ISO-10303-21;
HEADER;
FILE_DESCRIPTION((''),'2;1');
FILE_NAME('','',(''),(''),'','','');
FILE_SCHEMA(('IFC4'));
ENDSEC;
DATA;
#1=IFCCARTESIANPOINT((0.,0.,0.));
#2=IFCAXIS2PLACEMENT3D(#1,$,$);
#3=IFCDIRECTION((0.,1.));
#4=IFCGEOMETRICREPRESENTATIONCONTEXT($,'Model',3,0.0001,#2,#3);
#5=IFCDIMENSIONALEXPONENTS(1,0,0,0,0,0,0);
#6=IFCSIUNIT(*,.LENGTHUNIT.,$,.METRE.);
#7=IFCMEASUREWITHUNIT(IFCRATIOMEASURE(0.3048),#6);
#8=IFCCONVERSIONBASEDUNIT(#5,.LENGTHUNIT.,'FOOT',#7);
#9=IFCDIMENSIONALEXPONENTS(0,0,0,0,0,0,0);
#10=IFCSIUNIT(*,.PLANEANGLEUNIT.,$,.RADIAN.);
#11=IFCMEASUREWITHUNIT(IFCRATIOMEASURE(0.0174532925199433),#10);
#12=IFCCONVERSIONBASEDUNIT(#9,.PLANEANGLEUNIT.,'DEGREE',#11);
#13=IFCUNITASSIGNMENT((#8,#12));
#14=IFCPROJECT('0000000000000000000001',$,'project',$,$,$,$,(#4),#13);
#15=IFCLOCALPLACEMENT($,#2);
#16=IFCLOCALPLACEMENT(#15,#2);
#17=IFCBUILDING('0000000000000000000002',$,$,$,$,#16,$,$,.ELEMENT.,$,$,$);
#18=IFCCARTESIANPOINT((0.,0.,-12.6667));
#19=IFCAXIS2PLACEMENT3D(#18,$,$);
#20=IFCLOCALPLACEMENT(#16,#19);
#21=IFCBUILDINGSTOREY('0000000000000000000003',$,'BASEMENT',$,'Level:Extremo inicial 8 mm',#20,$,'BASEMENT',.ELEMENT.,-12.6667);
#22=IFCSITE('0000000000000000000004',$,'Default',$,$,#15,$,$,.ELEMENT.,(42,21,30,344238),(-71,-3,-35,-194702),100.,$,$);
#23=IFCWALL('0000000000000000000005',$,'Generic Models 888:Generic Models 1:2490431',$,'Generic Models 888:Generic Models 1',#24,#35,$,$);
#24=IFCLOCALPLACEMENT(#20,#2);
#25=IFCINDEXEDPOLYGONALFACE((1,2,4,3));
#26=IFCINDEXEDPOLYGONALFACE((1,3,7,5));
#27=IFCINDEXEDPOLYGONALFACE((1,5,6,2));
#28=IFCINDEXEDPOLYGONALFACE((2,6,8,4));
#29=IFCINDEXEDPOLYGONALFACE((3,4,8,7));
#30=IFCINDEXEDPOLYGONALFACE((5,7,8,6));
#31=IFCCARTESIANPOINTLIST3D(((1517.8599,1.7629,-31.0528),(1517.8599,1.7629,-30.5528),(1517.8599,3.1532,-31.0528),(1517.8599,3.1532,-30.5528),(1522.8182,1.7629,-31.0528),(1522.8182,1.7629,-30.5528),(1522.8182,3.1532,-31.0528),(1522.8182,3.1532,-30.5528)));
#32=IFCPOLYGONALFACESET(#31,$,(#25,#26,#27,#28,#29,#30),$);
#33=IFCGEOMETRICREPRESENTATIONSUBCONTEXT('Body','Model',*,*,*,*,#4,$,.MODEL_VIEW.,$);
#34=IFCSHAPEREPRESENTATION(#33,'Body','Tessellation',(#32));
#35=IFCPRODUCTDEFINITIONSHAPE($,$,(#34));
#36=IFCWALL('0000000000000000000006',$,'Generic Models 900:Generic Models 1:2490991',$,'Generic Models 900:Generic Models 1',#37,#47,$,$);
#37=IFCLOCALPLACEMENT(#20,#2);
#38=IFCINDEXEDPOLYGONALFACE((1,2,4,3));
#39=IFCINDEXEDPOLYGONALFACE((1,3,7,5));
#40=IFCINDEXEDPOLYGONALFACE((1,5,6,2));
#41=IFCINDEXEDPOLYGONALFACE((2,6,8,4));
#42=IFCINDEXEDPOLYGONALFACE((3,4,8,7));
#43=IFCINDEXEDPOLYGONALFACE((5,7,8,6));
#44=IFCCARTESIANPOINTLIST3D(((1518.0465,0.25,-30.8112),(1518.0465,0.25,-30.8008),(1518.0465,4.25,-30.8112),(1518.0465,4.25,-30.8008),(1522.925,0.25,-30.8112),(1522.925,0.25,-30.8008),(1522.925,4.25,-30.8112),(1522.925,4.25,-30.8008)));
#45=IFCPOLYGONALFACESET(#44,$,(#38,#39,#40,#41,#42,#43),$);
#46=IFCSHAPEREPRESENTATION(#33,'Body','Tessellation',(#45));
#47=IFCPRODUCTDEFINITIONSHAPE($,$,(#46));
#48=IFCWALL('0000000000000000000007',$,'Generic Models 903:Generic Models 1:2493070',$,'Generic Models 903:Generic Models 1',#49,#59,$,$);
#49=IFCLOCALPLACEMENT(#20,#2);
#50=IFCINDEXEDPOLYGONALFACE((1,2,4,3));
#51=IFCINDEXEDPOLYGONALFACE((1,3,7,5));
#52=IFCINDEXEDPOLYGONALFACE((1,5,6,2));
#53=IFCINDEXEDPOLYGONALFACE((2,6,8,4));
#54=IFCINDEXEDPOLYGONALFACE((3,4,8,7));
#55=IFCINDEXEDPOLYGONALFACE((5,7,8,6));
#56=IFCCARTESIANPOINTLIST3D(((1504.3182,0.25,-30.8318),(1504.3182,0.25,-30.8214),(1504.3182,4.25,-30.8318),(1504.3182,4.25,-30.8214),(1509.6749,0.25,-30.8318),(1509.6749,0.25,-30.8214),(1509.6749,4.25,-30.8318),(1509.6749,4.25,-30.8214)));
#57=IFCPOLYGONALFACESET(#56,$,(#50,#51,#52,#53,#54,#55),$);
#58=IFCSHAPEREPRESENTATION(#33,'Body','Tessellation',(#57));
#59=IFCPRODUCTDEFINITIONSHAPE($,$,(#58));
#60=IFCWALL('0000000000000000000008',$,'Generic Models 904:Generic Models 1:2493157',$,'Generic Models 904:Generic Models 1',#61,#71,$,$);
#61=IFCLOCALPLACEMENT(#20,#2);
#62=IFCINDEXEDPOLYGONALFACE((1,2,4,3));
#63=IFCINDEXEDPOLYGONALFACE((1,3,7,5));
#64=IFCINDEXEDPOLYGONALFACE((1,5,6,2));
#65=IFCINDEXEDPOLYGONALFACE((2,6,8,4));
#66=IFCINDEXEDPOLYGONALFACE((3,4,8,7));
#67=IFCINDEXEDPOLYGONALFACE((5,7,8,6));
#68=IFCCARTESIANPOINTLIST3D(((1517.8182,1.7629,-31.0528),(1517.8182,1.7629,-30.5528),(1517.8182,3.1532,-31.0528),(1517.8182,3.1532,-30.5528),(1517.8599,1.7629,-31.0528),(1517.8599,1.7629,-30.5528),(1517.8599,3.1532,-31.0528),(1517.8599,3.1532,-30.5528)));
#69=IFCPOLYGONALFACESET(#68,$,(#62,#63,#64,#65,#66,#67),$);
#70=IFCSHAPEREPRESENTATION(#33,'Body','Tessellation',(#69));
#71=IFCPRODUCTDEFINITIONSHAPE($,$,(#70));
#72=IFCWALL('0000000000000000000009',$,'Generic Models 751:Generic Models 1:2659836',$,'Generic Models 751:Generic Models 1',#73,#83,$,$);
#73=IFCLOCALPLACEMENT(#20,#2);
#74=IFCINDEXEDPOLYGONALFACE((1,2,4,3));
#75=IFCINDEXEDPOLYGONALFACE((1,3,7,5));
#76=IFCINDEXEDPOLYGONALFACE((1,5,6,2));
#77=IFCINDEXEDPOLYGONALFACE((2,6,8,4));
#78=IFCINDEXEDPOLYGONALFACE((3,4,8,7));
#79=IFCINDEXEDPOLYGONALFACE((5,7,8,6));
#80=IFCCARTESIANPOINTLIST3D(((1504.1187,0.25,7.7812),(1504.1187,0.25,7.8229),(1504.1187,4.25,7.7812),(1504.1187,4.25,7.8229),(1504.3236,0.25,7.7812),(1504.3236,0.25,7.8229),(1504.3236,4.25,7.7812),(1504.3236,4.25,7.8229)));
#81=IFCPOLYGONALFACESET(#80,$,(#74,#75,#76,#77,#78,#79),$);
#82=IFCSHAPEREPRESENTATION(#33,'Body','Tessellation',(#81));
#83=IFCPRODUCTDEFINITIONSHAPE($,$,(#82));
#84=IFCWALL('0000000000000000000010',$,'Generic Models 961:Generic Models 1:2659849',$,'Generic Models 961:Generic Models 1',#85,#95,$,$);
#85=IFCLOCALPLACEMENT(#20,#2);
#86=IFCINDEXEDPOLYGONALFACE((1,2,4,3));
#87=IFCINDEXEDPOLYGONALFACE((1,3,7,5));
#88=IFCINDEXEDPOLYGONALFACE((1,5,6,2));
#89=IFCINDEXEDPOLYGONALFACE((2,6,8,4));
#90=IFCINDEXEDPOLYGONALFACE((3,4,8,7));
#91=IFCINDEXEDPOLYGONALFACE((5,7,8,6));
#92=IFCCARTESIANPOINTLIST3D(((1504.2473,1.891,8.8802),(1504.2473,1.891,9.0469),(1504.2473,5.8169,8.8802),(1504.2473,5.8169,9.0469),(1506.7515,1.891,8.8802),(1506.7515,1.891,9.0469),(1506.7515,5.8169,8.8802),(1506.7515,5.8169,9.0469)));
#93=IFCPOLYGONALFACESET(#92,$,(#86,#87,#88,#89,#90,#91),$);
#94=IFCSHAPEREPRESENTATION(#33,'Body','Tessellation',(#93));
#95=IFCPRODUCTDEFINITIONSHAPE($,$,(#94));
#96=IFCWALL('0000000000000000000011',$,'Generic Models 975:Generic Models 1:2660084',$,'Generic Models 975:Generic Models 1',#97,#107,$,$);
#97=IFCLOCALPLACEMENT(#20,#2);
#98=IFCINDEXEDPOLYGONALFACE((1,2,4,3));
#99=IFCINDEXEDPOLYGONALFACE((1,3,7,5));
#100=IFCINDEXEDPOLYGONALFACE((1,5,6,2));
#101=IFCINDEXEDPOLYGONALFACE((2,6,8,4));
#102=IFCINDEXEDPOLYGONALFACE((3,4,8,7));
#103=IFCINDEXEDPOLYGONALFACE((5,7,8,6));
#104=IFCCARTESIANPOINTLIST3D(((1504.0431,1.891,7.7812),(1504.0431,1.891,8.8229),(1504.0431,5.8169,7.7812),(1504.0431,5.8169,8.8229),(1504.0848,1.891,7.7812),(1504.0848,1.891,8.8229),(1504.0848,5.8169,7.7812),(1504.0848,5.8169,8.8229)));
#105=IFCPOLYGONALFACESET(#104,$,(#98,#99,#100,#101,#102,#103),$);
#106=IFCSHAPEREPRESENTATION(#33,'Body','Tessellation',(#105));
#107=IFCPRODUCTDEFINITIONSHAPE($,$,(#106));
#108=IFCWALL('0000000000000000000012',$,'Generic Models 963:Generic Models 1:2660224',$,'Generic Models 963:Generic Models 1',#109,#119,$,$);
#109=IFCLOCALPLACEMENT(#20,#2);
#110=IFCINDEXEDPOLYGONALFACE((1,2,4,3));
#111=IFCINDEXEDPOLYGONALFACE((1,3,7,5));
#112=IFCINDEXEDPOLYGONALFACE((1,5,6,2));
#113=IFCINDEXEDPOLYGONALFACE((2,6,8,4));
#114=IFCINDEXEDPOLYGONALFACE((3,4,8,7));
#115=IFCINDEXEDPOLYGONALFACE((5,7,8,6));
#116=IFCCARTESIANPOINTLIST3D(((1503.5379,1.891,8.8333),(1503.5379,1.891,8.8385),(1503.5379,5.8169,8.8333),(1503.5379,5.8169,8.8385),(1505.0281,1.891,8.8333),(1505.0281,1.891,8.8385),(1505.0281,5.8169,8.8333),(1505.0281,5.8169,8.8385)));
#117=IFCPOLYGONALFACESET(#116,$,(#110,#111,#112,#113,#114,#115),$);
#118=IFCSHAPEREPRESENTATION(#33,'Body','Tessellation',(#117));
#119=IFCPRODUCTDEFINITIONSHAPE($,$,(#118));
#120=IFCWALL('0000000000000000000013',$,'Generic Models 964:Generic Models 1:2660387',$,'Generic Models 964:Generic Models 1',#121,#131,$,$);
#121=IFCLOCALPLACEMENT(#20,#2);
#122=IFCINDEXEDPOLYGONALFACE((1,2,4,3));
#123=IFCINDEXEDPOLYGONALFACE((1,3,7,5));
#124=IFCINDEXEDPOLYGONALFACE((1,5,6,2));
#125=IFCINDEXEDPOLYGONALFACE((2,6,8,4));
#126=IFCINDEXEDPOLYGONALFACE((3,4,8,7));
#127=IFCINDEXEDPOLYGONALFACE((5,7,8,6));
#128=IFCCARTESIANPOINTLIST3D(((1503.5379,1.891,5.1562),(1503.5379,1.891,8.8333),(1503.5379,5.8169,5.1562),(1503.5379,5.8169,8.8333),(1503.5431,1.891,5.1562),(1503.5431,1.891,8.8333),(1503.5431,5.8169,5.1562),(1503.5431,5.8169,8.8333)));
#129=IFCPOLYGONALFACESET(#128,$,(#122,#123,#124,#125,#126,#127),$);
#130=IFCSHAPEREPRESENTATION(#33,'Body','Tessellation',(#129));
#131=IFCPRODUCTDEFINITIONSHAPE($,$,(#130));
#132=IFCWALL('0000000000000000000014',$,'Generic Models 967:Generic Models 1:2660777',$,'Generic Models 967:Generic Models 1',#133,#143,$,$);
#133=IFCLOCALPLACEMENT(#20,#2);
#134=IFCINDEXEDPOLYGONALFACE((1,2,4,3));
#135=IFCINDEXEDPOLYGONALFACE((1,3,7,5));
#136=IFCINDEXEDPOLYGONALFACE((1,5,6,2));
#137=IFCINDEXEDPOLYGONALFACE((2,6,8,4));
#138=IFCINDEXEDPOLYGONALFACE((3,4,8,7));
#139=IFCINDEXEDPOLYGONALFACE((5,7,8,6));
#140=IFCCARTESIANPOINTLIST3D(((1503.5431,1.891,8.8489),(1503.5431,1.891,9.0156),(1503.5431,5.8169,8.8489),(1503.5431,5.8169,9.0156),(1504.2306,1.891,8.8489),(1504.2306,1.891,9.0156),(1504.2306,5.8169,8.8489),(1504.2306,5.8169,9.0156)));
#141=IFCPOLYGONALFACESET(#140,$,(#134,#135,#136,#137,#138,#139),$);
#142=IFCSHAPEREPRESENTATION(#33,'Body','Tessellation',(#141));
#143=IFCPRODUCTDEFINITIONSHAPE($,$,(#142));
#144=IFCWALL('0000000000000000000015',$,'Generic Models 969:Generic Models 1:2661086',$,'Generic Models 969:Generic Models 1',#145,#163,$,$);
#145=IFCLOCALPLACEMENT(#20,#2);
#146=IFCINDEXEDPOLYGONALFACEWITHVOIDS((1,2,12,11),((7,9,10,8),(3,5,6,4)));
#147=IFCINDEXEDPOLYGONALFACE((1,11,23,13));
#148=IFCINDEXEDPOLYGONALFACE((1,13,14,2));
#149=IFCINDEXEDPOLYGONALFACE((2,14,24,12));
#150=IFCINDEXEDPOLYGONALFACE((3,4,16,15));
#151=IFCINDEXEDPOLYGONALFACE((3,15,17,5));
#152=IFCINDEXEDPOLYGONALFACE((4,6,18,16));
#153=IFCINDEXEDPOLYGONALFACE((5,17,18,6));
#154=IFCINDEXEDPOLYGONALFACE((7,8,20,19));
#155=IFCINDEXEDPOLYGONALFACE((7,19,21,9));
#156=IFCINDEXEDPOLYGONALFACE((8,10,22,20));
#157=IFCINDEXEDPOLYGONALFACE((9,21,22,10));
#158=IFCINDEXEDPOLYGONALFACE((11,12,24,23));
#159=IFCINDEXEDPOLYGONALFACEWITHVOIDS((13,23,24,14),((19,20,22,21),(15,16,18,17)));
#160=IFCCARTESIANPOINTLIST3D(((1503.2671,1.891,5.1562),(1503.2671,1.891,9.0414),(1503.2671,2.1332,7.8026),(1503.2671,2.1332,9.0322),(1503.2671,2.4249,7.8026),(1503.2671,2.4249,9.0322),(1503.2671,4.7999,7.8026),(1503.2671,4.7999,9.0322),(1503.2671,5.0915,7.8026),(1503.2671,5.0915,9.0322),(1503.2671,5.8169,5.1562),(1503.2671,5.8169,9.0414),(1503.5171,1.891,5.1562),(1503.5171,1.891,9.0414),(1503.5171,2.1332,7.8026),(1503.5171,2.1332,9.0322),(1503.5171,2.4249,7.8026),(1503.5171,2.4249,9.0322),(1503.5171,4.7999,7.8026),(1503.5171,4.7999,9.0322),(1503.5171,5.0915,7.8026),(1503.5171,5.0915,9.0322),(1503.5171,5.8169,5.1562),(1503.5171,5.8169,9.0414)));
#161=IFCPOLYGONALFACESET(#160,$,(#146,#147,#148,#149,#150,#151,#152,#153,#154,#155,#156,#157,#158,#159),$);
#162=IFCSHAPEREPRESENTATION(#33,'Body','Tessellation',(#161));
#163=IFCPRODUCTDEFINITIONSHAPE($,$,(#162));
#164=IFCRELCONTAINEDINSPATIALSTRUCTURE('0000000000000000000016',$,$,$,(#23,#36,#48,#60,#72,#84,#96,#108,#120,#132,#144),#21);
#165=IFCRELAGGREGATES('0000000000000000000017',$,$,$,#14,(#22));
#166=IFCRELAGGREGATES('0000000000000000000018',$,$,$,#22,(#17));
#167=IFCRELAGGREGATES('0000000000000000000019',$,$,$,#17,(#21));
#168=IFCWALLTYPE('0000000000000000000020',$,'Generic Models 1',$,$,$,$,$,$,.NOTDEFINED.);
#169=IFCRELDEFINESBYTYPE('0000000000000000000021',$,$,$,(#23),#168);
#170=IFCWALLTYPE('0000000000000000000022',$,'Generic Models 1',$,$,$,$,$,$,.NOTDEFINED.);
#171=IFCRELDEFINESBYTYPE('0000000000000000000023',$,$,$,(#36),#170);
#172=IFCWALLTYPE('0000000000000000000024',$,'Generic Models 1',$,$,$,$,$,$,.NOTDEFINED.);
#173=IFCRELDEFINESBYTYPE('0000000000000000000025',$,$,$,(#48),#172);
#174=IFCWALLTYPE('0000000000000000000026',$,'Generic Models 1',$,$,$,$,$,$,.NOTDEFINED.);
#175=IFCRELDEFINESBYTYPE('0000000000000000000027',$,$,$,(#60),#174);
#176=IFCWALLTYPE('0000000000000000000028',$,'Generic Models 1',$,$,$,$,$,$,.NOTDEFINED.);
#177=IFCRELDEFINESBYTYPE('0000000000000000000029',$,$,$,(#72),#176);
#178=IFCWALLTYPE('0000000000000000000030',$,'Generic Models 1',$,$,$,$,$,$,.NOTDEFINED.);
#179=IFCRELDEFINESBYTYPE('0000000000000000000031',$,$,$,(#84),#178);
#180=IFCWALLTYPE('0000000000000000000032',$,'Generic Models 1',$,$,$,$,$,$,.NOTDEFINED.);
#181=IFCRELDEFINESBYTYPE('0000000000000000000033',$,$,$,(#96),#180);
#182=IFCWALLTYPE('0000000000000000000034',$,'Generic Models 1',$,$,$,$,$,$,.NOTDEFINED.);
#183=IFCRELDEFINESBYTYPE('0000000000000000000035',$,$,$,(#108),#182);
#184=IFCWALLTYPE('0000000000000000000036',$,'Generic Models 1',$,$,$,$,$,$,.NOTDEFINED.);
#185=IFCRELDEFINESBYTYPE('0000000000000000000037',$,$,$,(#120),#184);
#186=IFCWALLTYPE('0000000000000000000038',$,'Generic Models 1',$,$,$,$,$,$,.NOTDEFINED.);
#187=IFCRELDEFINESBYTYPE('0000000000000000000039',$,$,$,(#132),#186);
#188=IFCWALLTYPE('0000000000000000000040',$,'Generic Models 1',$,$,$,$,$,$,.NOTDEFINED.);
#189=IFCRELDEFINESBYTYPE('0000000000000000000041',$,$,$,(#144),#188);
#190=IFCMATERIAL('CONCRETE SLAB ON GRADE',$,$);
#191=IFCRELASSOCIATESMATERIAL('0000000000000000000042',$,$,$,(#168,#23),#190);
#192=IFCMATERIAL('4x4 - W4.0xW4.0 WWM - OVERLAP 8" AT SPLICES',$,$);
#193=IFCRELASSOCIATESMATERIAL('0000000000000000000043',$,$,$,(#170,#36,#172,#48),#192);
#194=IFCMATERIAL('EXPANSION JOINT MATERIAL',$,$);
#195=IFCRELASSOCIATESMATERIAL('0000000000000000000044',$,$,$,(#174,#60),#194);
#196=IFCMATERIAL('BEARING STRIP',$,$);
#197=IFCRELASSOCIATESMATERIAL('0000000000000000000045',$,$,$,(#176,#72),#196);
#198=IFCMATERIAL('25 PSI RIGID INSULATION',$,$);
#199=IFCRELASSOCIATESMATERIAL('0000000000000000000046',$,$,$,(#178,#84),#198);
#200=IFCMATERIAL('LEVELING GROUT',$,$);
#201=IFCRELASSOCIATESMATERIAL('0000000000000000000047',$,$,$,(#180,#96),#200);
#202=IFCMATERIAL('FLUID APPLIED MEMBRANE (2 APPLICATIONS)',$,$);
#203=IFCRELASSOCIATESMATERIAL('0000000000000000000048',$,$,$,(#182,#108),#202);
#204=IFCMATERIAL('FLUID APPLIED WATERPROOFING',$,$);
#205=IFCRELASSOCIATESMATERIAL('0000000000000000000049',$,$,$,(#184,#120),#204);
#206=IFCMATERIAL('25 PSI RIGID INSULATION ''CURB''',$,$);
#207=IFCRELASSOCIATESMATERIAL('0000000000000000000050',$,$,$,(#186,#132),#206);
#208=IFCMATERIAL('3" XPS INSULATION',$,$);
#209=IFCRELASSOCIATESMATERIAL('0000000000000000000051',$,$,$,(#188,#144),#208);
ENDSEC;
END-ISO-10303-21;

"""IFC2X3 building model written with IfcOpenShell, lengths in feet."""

from ifc_helpers import new_model, entity, si_unit, converted_unit, direction, frame, frame_2d, origin, origin_2d_with_axis, place, context, subcontext, project, spatial, rectangle, extrude, material, type_object, element, save


model = new_model("IFC2X3")

# Units and contexts
model_context = context("Model", 3, precision=0.0001, world=origin(), true_north=direction((0.0, 1.0)))
body_context = subcontext(model_context, "Body", "Model", "MODEL_VIEW")
ifc_project = project(units=[converted_unit("LENGTHUNIT", "FOOT", entity("IfcRatioMeasure", 0.3048), si_unit("LENGTHUNIT", "METRE"), dimensions=[1, 0, 0, 0, 0, 0, 0]), converted_unit("PLANEANGLEUNIT", "DEGREE", entity("IfcRatioMeasure", 0.0174532925199433), si_unit("PLANEANGLEUNIT", "RADIAN"), dimensions=[0, 0, 0, 0, 0, 0, 0])], contexts=[model_context])

# Site, building, storey
site_placement = place(None, origin())
site = spatial("IfcSite", under=ifc_project, at=site_placement, Name="Default", CompositionType="ELEMENT", RefLatitude=(42, 21, 30, 344238), RefLongitude=(-71, -3, -35, -194702), RefElevation=100.0)
building_placement = place(site_placement, origin())
building = spatial("IfcBuilding", under=site, at=building_placement, CompositionType="ELEMENT")
storey_placement = place(building_placement, frame((0.0, 0.0, -12.6667)))
storey = spatial("IfcBuildingStorey", under=building, at=storey_placement, Name="BASEMENT", ObjectType="Level:Extremo inicial 8 mm", LongName="BASEMENT", CompositionType="ELEMENT", Elevation=-12.6667)

# Walls
ifc_material_1 = material(Name="CONCRETE SLAB ON GRADE")
wall_type_1 = type_object("IfcWallType", Name="Generic Models 1", PredefinedType="NOTDEFINED", material=ifc_material_1)
wall_1_placement = place(storey_placement, frame((1517.8599, 1.7629, -31.0528)))
element("IfcWall", 1, at=wall_1_placement, inside=storey, type_object=wall_type_1, material=ifc_material_1, Name="Generic Models 888:Generic Models 1:2490431", ObjectType="Generic Models 888:Generic Models 1", context=body_context, shape_type="SweptSolid", body=[
    extrude(rectangle(XDim=1.3904, YDim=4.9583, at=frame_2d((0.0, 0.0), x_axis=(1.0, 0.0))), frame((2.4792, 0.6952, 0.0), z_axis=(0.0, 0.0, 1.0), x_axis=(0.0, 1.0, 0.0)), (0.0, 0.0, 1.0), 0.5),
])
ifc_material_2 = material(Name="4x4 - W4.0xW4.0 WWM - OVERLAP 8\" AT SPLICES")
wall_type_2 = type_object("IfcWallType", Name="Generic Models 1", PredefinedType="NOTDEFINED", material=ifc_material_2)
wall_2_placement = place(storey_placement, frame((1518.0465, 0.25, -30.8112)))
element("IfcWall", 2, at=wall_2_placement, inside=storey, type_object=wall_type_2, material=ifc_material_2, Name="Generic Models 900:Generic Models 1:2490991", ObjectType="Generic Models 900:Generic Models 1", context=body_context, shape_type="SweptSolid", body=[
    extrude(rectangle(XDim=4.0, YDim=4.8785, at=frame_2d((0.0, 0.0), x_axis=(1.0, 0.0))), frame((2.4393, 2.0, 0.0), z_axis=(0.0, 0.0, 1.0), x_axis=(0.0, 1.0, 0.0)), (0.0, 0.0, 1.0), 0.0104),
])
wall_type_3 = type_object("IfcWallType", Name="Generic Models 1", PredefinedType="NOTDEFINED", material=ifc_material_2)
wall_3_placement = place(storey_placement, frame((1504.3182, 0.25, -30.8318)))
element("IfcWall", 3, at=wall_3_placement, inside=storey, type_object=wall_type_3, material=ifc_material_2, Name="Generic Models 903:Generic Models 1:2493070", ObjectType="Generic Models 903:Generic Models 1", context=body_context, shape_type="SweptSolid", body=[
    extrude(rectangle(XDim=4.0, YDim=5.3567, at=frame_2d((0.0, 0.0), x_axis=(1.0, 0.0))), frame((2.6784, 2.0, 0.0), z_axis=(0.0, 0.0, 1.0), x_axis=(0.0, 1.0, 0.0)), (0.0, 0.0, 1.0), 0.0104),
])
ifc_material_3 = material(Name="EXPANSION JOINT MATERIAL")
wall_type_4 = type_object("IfcWallType", Name="Generic Models 1", PredefinedType="NOTDEFINED", material=ifc_material_3)
wall_4_placement = place(storey_placement, frame((1517.8182, 1.7629, -31.0528), z_axis=(0.0, 0.0, 1.0), x_axis=(0.0, 1.0, 0.0)))
element("IfcWall", 4, at=wall_4_placement, inside=storey, type_object=wall_type_4, material=ifc_material_3, Name="Generic Models 904:Generic Models 1:2493157", ObjectType="Generic Models 904:Generic Models 1", context=body_context, shape_type="SweptSolid", body=[
    extrude(rectangle(XDim=1.3904, YDim=0.0417, at=frame_2d((0.0, 0.0), x_axis=(1.0, 0.0))), frame((0.6952, -0.0208, 0.0)), (0.0, 0.0, 1.0), 0.5),
])
ifc_material_4 = material(Name="BEARING STRIP")
wall_type_5 = type_object("IfcWallType", Name="Generic Models 1", PredefinedType="NOTDEFINED", material=ifc_material_4)
wall_5_placement = place(storey_placement, frame((1504.1187, 0.25, 7.7812), z_axis=(0.0, 0.0, 1.0), x_axis=(0.0, 1.0, 0.0)))
element("IfcWall", 5, at=wall_5_placement, inside=storey, type_object=wall_type_5, material=ifc_material_4, Name="Generic Models 751:Generic Models 1:2659836", ObjectType="Generic Models 751:Generic Models 1", context=body_context, shape_type="SweptSolid", body=[
    extrude(rectangle(XDim=4.0, YDim=0.205, at=frame_2d((0.0, 0.0), x_axis=(1.0, 0.0))), frame((2.0, -0.1025, 0.0)), (0.0, 0.0, 1.0), 0.0417),
])
ifc_material_5 = material(Name="25 PSI RIGID INSULATION")
wall_type_6 = type_object("IfcWallType", Name="Generic Models 1", PredefinedType="NOTDEFINED", material=ifc_material_5)
wall_6_placement = place(storey_placement, frame((1504.2473, 1.891, 8.8802), z_axis=(0.0, 0.0, 1.0), x_axis=(0.0, 1.0, 0.0)))
element("IfcWall", 6, at=wall_6_placement, inside=storey, type_object=wall_type_6, material=ifc_material_5, Name="Generic Models 961:Generic Models 1:2659849", ObjectType="Generic Models 961:Generic Models 1", context=body_context, shape_type="SweptSolid", body=[
    extrude(rectangle(XDim=3.9258, YDim=2.5042, at=frame_2d((0.0, 0.0), x_axis=(1.0, 0.0))), frame((1.9629, -1.2521, 0.0)), (0.0, 0.0, 1.0), 0.1667),
])
ifc_material_6 = material(Name="LEVELING GROUT")
wall_type_7 = type_object("IfcWallType", Name="Generic Models 1", PredefinedType="NOTDEFINED", material=ifc_material_6)
wall_7_placement = place(storey_placement, frame((1504.0431, 1.891, 7.7812), z_axis=(0.0, 0.0, 1.0), x_axis=(0.0, 1.0, 0.0)))
element("IfcWall", 7, at=wall_7_placement, inside=storey, type_object=wall_type_7, material=ifc_material_6, Name="Generic Models 975:Generic Models 1:2660084", ObjectType="Generic Models 975:Generic Models 1", context=body_context, shape_type="SweptSolid", body=[
    extrude(rectangle(XDim=3.9258, YDim=0.0417, at=frame_2d((0.0, 0.0), x_axis=(1.0, 0.0))), frame((1.9629, -0.0208, 0.0)), (0.0, 0.0, 1.0), 1.0417),
])
ifc_material_7 = material(Name="FLUID APPLIED MEMBRANE (2 APPLICATIONS)")
wall_type_8 = type_object("IfcWallType", Name="Generic Models 1", PredefinedType="NOTDEFINED", material=ifc_material_7)
wall_8_placement = place(storey_placement, frame((1503.5379, 1.891, 8.8333), z_axis=(0.0, 0.0, 1.0), x_axis=(0.0, 1.0, 0.0)))
element("IfcWall", 8, at=wall_8_placement, inside=storey, type_object=wall_type_8, material=ifc_material_7, Name="Generic Models 963:Generic Models 1:2660224", ObjectType="Generic Models 963:Generic Models 1", context=body_context, shape_type="SweptSolid", body=[
    extrude(rectangle(XDim=3.9258, YDim=1.4902, at=frame_2d((0.0, 0.0), x_axis=(1.0, 0.0))), frame((1.9629, -0.7451, 0.0)), (0.0, 0.0, 1.0), 0.0052),
])
ifc_material_8 = material(Name="FLUID APPLIED WATERPROOFING")
wall_type_9 = type_object("IfcWallType", Name="Generic Models 1", PredefinedType="NOTDEFINED", material=ifc_material_8)
wall_9_placement = place(storey_placement, frame((1503.5379, 1.891, 5.1562), z_axis=(0.0, 0.0, 1.0), x_axis=(0.0, 1.0, 0.0)))
element("IfcWall", 9, at=wall_9_placement, inside=storey, type_object=wall_type_9, material=ifc_material_8, Name="Generic Models 964:Generic Models 1:2660387", ObjectType="Generic Models 964:Generic Models 1", context=body_context, shape_type="SweptSolid", body=[
    extrude(rectangle(XDim=3.9258, YDim=0.0052, at=frame_2d((0.0, 0.0), x_axis=(1.0, 0.0))), frame((1.9629, -0.0026, 0.0)), (0.0, 0.0, 1.0), 3.6771),
])
ifc_material_9 = material(Name="25 PSI RIGID INSULATION 'CURB'")
wall_type_10 = type_object("IfcWallType", Name="Generic Models 1", PredefinedType="NOTDEFINED", material=ifc_material_9)
wall_10_placement = place(storey_placement, frame((1503.5431, 1.891, 8.8489), z_axis=(0.0, 0.0, 1.0), x_axis=(0.0, 1.0, 0.0)))
element("IfcWall", 10, at=wall_10_placement, inside=storey, type_object=wall_type_10, material=ifc_material_9, Name="Generic Models 967:Generic Models 1:2660777", ObjectType="Generic Models 967:Generic Models 1", context=body_context, shape_type="SweptSolid", body=[
    extrude(rectangle(XDim=3.9258, YDim=0.6875, at=origin_2d_with_axis()), frame((1.9629, -0.3438, 0.0)), (0.0, 0.0, 1.0), 0.1667),
])

# Wall, openings
ifc_material_10 = material(Name="3\" XPS INSULATION")
wall_type_11 = type_object("IfcWallType", Name="Generic Models 1", PredefinedType="NOTDEFINED", material=ifc_material_10)
wall_11_placement = place(storey_placement, frame((1503.2671, 1.891, 5.1562), z_axis=(0.0, 0.0, 1.0), x_axis=(0.0, 1.0, 0.0)))
wall_11 = element("IfcWall", 11, at=wall_11_placement, inside=storey, type_object=wall_type_11, material=ifc_material_10, Name="Generic Models 969:Generic Models 1:2661086", ObjectType="Generic Models 969:Generic Models 1", context=body_context, shape_type="SweptSolid", body=[
    extrude(rectangle(XDim=3.9258, YDim=0.25, at=frame_2d((0.0, 0.0), x_axis=(1.0, 0.0))), frame((1.9629, -0.125, 0.0), z_axis=(0.0, 0.0, 1.0), x_axis=(-1.0, 0.0, 0.0)), (0.0, 0.0, 1.0), 3.8851),
])
opening_1_placement = place(storey_placement, frame((1503.2671, 1.891, 5.1562), z_axis=(0.0, 0.0, 1.0), x_axis=(0.0, 1.0, 0.0)))
element("IfcOpeningElement", 12, at=opening_1_placement, cuts=wall_11, ObjectType="Opening", context=body_context, shape_type="SweptSolid", body=[
    extrude(rectangle(XDim=1.2295, YDim=0.2917, at=origin_2d_with_axis()), frame((0.388, -0.25, 3.2612), z_axis=(0.0, 1.0, 0.0), x_axis=(0.0, 0.0, 1.0)), (0.0, 0.0, 1.0), 0.25),
])
opening_2_placement = place(storey_placement, frame((1503.2671, 1.891, 5.1562), z_axis=(0.0, 0.0, 1.0), x_axis=(0.0, 1.0, 0.0)))
element("IfcOpeningElement", 13, at=opening_2_placement, cuts=wall_11, ObjectType="Opening", context=body_context, shape_type="SweptSolid", body=[
    extrude(rectangle(XDim=1.2295, YDim=0.2917, at=frame_2d((0.0, 0.0), x_axis=(1.0, 0.0))), frame((3.0547, -0.25, 3.2612), z_axis=(0.0, 1.0, 0.0), x_axis=(0.0, 0.0, 1.0)), (0.0, 0.0, 1.0), 0.25),
])

save(model, "model.ifc")
